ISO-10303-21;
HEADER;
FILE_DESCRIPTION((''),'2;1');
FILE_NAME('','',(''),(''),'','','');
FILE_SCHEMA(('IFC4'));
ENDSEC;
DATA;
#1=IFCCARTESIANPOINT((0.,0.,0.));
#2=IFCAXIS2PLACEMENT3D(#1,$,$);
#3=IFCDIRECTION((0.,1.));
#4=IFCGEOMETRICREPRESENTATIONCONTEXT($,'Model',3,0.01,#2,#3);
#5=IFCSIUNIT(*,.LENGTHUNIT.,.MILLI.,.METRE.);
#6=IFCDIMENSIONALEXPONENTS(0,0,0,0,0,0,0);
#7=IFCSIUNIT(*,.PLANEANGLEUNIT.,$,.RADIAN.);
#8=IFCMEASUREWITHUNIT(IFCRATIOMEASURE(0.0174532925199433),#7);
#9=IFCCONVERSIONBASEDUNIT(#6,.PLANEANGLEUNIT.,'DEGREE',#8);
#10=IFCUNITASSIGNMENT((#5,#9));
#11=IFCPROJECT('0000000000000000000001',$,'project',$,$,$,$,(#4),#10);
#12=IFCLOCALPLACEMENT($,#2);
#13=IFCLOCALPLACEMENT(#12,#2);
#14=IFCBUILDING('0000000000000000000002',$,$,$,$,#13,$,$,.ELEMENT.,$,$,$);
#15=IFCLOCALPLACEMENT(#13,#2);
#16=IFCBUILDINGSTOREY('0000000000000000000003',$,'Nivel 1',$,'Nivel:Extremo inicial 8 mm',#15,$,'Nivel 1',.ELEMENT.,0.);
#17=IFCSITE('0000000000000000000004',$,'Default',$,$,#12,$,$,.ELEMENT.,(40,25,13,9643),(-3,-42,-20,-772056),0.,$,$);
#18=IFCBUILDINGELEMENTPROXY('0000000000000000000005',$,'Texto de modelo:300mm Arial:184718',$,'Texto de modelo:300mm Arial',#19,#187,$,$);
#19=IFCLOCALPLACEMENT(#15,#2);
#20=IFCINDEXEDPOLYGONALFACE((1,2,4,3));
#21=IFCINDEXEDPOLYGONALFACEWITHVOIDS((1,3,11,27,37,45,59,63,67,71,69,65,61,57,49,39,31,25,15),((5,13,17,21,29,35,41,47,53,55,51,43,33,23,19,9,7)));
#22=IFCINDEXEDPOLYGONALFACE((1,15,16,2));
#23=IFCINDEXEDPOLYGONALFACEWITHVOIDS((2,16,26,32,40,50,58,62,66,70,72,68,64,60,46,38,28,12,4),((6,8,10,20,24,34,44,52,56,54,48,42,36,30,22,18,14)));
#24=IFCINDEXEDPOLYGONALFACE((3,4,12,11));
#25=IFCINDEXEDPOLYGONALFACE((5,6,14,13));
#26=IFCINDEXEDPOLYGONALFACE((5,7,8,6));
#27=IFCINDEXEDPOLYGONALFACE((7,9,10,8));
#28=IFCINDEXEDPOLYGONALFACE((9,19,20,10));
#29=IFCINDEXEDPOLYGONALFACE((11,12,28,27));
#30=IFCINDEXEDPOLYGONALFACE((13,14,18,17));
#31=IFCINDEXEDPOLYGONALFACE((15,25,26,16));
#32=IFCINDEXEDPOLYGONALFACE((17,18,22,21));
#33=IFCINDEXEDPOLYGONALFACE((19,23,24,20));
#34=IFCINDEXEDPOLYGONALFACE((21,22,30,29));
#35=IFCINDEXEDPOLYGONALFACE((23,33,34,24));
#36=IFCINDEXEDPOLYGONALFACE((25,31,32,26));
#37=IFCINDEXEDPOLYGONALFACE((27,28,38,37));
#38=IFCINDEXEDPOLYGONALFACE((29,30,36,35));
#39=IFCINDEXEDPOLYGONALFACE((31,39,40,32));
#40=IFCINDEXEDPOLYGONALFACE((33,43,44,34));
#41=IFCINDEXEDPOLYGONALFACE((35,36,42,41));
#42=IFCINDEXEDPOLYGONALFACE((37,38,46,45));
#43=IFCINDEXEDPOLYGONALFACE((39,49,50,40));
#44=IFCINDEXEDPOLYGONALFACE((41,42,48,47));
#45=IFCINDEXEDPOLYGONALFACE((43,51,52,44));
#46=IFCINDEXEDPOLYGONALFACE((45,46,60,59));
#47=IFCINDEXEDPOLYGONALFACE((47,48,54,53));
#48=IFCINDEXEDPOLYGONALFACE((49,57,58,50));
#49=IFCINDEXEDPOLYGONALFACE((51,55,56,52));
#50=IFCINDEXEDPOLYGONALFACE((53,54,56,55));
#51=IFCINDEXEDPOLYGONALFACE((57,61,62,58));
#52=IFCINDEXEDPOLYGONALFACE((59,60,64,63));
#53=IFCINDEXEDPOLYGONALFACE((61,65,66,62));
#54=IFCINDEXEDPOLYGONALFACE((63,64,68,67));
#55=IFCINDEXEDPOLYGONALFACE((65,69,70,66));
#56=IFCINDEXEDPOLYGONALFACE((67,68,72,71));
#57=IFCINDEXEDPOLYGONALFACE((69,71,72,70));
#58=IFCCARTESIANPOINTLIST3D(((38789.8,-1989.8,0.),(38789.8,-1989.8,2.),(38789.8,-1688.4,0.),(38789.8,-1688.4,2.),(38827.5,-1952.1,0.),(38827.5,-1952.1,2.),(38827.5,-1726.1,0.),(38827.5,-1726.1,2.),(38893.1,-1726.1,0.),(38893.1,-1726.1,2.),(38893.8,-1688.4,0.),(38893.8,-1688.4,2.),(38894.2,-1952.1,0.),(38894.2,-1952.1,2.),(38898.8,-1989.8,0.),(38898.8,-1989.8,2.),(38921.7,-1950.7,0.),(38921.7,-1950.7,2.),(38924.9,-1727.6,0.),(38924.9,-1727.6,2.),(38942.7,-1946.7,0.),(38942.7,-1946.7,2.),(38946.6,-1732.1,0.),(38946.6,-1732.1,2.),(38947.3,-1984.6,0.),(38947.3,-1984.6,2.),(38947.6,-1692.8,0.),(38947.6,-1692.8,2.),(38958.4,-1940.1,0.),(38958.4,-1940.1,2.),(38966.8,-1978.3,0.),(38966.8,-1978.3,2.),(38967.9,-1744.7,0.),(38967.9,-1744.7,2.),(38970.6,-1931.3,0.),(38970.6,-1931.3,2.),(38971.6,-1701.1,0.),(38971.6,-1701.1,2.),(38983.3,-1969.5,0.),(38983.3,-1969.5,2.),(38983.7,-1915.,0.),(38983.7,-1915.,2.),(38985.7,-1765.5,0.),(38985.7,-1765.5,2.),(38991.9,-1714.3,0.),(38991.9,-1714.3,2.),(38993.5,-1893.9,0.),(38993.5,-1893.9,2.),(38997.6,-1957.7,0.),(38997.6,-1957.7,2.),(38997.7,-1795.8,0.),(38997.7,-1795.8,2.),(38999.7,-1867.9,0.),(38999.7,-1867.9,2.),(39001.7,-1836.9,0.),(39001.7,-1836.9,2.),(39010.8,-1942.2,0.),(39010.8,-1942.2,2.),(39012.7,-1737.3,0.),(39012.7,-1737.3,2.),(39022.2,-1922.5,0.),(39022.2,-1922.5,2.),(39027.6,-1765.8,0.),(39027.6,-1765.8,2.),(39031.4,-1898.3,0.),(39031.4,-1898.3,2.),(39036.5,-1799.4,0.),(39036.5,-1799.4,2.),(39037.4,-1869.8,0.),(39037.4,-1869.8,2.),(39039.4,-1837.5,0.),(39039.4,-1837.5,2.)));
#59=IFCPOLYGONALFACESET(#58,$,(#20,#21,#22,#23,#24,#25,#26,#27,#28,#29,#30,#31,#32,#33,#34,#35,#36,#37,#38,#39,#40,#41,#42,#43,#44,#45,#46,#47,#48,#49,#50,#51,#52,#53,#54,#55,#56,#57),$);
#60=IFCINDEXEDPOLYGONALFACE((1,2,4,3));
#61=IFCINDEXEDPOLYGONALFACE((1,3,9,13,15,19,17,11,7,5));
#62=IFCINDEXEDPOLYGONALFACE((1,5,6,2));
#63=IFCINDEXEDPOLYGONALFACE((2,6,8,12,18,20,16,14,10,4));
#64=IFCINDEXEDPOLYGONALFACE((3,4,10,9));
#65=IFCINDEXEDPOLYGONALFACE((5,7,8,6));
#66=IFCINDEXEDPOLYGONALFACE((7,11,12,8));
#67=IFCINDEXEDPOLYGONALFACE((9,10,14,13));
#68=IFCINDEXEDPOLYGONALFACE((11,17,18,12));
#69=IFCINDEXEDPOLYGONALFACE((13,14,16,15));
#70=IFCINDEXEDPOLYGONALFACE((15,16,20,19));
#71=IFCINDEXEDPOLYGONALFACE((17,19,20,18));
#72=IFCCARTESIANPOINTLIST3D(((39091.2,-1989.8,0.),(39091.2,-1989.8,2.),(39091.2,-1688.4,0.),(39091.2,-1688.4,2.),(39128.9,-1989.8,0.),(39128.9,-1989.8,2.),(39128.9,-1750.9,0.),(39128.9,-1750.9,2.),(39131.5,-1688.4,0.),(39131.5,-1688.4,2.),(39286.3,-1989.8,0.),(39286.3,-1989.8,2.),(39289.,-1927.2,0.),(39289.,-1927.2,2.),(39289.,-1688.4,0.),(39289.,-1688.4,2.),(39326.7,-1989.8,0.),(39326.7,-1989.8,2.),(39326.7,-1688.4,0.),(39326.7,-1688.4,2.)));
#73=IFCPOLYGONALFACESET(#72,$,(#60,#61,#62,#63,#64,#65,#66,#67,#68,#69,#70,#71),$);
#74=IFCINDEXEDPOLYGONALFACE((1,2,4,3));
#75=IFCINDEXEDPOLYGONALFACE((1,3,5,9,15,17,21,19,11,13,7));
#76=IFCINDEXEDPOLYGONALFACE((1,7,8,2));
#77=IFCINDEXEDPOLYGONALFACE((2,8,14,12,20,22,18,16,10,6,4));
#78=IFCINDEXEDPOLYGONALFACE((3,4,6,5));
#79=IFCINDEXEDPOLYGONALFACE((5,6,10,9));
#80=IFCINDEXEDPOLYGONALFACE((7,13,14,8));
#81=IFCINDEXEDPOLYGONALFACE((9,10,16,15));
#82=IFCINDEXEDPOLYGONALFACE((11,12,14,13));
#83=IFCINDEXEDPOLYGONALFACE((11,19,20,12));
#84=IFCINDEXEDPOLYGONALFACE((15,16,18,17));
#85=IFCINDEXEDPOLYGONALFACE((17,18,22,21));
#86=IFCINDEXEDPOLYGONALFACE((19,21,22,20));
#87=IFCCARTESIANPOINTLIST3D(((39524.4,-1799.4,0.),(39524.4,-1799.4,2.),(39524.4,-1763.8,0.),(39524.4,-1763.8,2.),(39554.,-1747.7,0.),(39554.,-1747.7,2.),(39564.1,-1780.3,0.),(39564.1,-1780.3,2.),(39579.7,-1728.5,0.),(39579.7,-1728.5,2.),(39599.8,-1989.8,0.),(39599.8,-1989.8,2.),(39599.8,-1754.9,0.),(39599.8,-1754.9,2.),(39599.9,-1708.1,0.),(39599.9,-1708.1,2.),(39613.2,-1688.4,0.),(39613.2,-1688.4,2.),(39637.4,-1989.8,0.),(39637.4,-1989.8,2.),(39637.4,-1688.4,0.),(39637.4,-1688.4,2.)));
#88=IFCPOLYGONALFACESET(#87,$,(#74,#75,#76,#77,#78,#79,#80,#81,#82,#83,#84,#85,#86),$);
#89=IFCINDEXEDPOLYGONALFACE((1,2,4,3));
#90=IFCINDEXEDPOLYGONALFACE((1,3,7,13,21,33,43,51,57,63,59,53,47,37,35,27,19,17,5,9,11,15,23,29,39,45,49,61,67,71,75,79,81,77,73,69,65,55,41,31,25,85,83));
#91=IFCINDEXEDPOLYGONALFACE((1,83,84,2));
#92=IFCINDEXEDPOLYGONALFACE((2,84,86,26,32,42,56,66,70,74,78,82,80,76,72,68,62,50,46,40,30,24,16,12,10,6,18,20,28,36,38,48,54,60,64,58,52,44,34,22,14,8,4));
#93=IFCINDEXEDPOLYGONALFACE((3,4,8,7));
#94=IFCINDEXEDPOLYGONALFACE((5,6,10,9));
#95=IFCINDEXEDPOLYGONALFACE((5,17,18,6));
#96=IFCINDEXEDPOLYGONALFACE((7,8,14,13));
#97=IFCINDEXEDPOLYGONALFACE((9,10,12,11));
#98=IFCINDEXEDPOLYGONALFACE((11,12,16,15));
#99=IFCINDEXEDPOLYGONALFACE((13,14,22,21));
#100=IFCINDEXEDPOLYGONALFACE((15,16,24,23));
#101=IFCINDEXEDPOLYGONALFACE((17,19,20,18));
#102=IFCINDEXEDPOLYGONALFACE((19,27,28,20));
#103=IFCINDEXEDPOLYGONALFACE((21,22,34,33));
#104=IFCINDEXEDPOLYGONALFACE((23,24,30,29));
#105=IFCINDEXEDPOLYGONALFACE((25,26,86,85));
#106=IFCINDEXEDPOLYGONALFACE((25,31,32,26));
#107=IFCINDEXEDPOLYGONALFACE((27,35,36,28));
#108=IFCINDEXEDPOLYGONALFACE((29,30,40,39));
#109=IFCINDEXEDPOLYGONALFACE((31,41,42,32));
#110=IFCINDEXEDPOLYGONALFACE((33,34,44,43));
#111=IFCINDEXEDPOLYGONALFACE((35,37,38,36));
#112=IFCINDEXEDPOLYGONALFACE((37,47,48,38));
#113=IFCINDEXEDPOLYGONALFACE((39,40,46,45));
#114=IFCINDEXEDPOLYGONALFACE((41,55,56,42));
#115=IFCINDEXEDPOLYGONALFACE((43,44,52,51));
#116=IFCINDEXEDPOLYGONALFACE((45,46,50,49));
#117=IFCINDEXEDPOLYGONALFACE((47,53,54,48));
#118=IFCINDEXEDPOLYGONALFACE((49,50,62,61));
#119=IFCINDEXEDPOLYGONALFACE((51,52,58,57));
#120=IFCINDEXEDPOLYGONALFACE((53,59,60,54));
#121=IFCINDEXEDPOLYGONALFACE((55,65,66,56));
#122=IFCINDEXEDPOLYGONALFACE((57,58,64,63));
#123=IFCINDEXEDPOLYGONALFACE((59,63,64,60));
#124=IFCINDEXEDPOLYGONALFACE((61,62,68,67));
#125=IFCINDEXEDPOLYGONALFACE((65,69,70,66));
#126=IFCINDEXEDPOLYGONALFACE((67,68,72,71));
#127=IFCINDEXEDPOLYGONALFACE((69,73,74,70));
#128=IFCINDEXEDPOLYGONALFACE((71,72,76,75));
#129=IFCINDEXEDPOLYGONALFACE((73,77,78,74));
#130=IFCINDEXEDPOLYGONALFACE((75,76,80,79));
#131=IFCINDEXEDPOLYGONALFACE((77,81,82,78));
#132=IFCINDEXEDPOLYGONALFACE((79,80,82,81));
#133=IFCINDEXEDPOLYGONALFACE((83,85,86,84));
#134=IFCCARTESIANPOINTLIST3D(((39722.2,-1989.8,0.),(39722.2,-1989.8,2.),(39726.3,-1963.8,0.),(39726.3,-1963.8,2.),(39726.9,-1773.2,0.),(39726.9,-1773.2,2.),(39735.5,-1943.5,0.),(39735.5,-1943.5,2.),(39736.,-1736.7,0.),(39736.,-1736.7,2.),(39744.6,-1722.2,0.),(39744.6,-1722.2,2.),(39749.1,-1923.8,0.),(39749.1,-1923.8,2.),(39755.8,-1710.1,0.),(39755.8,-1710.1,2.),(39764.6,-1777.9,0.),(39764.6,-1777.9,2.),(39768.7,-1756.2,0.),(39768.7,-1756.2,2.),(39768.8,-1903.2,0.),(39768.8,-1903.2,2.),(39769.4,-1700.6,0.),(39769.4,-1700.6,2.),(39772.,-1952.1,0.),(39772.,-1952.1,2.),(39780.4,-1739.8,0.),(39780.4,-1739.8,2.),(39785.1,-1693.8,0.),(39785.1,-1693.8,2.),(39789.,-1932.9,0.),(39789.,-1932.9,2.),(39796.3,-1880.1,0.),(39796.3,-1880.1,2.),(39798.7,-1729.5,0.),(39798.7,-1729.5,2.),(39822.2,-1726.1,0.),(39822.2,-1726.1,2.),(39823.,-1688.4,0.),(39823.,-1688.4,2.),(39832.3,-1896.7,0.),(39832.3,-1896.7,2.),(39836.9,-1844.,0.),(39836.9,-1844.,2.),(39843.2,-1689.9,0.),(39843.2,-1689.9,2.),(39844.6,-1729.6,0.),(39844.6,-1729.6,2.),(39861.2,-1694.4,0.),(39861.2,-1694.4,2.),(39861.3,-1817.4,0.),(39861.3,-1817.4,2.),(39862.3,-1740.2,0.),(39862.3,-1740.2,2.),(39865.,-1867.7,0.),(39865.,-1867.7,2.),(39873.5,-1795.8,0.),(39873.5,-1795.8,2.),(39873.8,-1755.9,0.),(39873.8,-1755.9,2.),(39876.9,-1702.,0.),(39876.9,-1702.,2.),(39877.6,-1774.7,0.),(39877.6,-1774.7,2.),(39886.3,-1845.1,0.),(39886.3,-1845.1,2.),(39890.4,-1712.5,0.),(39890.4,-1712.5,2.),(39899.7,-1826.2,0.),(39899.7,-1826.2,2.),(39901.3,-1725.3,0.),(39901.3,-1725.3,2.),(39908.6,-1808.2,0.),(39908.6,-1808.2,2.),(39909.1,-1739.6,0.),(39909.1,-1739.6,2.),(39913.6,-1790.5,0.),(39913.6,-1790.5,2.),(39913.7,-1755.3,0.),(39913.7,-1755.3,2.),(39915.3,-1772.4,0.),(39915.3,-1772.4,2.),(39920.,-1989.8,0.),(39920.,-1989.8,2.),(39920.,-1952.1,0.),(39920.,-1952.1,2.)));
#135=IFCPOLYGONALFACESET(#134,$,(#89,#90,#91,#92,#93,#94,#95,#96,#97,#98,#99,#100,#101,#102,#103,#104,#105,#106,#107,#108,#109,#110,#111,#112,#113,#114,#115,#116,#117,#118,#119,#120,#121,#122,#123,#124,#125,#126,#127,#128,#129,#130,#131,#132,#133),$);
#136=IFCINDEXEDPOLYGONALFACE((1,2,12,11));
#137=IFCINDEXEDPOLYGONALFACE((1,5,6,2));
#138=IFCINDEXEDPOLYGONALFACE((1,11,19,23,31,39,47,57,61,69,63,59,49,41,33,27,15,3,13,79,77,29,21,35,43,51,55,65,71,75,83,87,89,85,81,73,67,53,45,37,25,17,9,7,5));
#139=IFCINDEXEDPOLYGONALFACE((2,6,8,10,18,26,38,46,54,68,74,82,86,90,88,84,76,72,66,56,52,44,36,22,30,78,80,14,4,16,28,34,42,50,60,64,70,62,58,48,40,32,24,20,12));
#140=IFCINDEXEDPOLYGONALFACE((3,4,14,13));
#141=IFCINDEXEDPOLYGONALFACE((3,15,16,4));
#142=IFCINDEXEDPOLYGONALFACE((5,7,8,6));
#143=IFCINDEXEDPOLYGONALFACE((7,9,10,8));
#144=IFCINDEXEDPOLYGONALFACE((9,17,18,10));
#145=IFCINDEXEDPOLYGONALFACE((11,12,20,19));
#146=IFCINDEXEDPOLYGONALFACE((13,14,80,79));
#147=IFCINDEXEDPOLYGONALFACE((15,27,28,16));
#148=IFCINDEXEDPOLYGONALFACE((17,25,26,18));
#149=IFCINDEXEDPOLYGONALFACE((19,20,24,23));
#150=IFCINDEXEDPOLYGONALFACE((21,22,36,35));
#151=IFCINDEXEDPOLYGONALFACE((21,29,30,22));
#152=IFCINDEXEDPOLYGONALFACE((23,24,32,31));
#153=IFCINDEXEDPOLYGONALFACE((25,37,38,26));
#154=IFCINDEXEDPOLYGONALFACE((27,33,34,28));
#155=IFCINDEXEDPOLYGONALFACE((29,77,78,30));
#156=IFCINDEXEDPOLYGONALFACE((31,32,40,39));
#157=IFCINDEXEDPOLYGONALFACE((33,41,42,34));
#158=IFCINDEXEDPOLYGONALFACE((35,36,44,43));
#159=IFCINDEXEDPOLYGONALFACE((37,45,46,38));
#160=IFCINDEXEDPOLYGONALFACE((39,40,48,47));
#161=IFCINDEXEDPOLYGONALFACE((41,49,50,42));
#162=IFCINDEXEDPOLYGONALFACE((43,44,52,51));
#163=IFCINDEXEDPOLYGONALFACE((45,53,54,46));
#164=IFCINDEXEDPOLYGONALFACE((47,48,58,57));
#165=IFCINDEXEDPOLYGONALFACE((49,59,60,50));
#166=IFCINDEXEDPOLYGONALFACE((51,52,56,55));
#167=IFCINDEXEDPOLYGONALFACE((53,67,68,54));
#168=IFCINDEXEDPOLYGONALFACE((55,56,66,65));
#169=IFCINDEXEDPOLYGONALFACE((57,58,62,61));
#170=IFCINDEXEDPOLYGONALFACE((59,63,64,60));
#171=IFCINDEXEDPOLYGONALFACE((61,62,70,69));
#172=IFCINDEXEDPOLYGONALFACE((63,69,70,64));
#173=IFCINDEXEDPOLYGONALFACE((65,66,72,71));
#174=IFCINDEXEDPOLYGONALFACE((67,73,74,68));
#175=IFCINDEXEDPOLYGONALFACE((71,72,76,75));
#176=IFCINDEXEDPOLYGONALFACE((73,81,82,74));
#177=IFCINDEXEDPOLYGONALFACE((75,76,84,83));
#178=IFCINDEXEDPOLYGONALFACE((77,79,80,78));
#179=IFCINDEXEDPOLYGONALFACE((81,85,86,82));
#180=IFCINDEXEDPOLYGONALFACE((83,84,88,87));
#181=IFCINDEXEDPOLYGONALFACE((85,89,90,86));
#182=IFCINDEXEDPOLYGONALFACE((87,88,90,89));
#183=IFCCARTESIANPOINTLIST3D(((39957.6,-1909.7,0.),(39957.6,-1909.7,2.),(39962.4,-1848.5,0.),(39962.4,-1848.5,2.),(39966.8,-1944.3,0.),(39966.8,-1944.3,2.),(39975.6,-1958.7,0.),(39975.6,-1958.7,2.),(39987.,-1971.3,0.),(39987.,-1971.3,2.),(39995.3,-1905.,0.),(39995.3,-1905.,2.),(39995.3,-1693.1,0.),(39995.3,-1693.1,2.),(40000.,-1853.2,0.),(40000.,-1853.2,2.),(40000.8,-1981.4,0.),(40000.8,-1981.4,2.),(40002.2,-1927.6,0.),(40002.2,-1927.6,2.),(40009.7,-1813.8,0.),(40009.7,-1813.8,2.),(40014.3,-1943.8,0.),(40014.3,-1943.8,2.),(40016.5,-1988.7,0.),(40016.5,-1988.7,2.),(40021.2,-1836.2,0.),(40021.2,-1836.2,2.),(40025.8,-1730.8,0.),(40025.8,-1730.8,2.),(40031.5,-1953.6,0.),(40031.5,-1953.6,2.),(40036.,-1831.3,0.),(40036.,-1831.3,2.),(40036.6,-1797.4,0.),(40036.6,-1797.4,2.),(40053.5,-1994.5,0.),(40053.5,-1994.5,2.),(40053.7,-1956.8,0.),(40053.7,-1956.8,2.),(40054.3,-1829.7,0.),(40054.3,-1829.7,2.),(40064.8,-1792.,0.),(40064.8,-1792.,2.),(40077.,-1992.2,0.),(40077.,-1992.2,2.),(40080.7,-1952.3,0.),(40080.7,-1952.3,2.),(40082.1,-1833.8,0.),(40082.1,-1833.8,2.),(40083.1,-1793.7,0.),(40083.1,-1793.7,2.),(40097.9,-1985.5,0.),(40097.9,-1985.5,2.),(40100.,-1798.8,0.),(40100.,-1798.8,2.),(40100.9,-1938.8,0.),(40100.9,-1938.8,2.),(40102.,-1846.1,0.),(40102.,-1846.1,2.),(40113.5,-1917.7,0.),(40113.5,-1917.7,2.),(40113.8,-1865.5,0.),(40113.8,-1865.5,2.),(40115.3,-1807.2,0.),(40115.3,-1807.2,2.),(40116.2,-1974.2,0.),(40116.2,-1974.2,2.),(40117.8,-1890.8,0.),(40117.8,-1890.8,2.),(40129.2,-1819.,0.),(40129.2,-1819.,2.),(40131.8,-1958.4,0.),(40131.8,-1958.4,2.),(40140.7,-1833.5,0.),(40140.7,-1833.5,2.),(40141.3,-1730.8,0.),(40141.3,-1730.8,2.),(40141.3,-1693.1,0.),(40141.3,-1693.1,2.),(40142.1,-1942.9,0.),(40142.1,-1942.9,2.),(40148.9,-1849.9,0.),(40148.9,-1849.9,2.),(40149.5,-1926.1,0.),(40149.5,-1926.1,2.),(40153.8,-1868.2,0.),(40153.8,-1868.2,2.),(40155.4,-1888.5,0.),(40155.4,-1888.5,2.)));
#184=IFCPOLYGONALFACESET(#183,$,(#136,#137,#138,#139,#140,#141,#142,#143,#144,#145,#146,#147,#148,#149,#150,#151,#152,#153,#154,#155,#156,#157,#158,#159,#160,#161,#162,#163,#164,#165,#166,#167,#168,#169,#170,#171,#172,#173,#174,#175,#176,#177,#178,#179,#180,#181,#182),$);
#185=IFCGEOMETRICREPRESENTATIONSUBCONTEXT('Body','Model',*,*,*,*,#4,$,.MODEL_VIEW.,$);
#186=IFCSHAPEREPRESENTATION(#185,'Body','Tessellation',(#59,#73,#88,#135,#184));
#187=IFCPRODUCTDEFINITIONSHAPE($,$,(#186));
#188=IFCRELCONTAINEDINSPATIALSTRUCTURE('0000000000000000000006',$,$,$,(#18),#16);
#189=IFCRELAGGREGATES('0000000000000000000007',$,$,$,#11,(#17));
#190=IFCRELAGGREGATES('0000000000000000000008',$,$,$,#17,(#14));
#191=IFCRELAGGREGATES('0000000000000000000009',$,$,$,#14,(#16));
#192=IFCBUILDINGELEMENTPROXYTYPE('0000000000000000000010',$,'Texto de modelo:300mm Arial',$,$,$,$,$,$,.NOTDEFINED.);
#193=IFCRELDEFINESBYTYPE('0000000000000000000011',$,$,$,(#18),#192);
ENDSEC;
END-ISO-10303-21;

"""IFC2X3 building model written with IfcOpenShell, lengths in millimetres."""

from ifc_helpers import new_model, entity, si_unit, converted_unit, direction, frame, origin, place, context, subcontext, project, spatial, polyline, outline, extrude, type_object, element, save


model = new_model("IFC2X3")

# Units and contexts
model_context = context("Model", 3, precision=0.01, world=origin(), true_north=direction((0.0, 1.0)))
body_context = subcontext(model_context, "Body", "Model", "MODEL_VIEW")
ifc_project = project(units=[si_unit("LENGTHUNIT", "METRE", prefix="MILLI"), converted_unit("PLANEANGLEUNIT", "DEGREE", entity("IfcRatioMeasure", 0.0174532925199433), si_unit("PLANEANGLEUNIT", "RADIAN"), dimensions=[0, 0, 0, 0, 0, 0, 0])], contexts=[model_context])

# Site, building, storey
site_placement = place(None, origin())
site = spatial("IfcSite", under=ifc_project, at=site_placement, Name="Default", CompositionType="ELEMENT", RefLatitude=(40, 25, 13, 9643), RefLongitude=(-3, -42, -20, -772056), RefElevation=0.0)
building_placement = place(site_placement, origin())
building = spatial("IfcBuilding", under=site, at=building_placement, CompositionType="ELEMENT")
storey_placement = place(building_placement, origin())
storey = spatial("IfcBuildingStorey", under=building, at=storey_placement, Name="Nivel 1", ObjectType="Nivel:Extremo inicial 8 mm", LongName="Nivel 1", CompositionType="ELEMENT", Elevation=0.0)

# Building element proxy
building_element_proxy_type_1 = type_object("IfcBuildingElementProxyType", Name="Texto de modelo:300mm Arial", PredefinedType="NOTDEFINED")
proxy_1_placement = place(storey_placement, frame((38789.8, -1994.5, 0.0)))
element("IfcBuildingElementProxy", 1, at=proxy_1_placement, inside=storey, type_object=building_element_proxy_type_1, Name="Texto de modelo:300mm Arial:184718", ObjectType="Texto de modelo:300mm Arial", context=body_context, shape_type="SweptSolid", body=[
    extrude(outline(polyline([(-178.4, -141.0), (-69.4, -141.0), (-21.0, -135.8), (-1.4, -129.5), (15.0, -120.7), (29.4, -108.9), (42.6, -93.4), (54.0, -73.7), (63.2, -49.5), (69.2, -21.0), (71.2, 11.3), (68.2, 49.4), (59.3, 83.0), (44.5, 111.5), (23.7, 134.5), (3.4, 147.7), (-20.6, 156.1), (-74.4, 160.4), (-178.4, 160.4), (-178.4, -141.0)]), holes=[polyline([(-140.7, -103.3), (-140.7, 122.7), (-75.1, 122.7), (-43.3, 121.2), (-21.7, 116.7), (-0.4, 104.1), (17.4, 83.3), (29.5, 53.0), (33.5, 11.9), (31.5, -19.1), (25.3, -45.1), (15.5, -66.2), (2.4, -82.5), (-9.8, -91.3), (-25.6, -97.9), (-46.5, -101.9), (-74.1, -103.3), (-140.7, -103.3)])]), frame((178.4, 145.7, 0.0)), (0.0, 0.0, 1.0), 2.0),
    extrude(outline(polyline([(-117.7, -150.7), (-80.1, -150.7), (-80.1, 88.1), (77.4, -150.7), (117.7, -150.7), (117.7, 150.7), (80.1, 150.7), (80.1, -88.1), (-77.4, 150.7), (-117.7, 150.7), (-117.7, -150.7)])), frame((419.1, 155.4, 0.0)), (0.0, 0.0, 1.0), 2.0),
    extrude(outline(polyline([(-204.4, -52.5), (97.0, -52.5), (97.0, -28.2), (77.2, -14.9), (56.9, 5.3), (37.7, 30.9), (21.6, 60.5), (-14.0, 60.5), (5.0, 20.8), (30.4, -14.9), (-204.4, -14.9), (-204.4, -52.5)])), frame((795.1, 209.1, 0.0), z_axis=(0.0, 0.0, 1.0), x_axis=(0.0, 1.0, 0.0)), (0.0, 0.0, 1.0), 2.0),
    extrude(outline(polyline([(-91.6, -150.5), (-91.6, -188.2), (106.2, -188.2), (102.1, -162.2), (92.9, -141.9), (79.3, -122.2), (59.6, -101.6), (32.1, -78.5), (-8.5, -42.4), (-32.9, -15.8), (-45.1, 5.8), (-49.2, 26.9), (-45.4, 45.8), (-33.9, 61.4), (-16.2, 72.0), (6.2, 75.5), (29.7, 72.1), (48.0, 61.8), (59.7, 45.4), (63.8, 23.7), (101.5, 28.4), (92.4, 64.9), (83.8, 79.4), (72.6, 91.5), (59.0, 101.0), (43.3, 107.8), (5.4, 113.2), (-14.8, 111.7), (-32.8, 107.2), (-48.5, 99.6), (-62.0, 89.1), (-72.9, 76.3), (-80.7, 62.0), (-85.3, 46.3), (-86.9, 29.2), (-85.2, 11.2), (-80.2, -6.5), (-71.3, -24.6), (-57.9, -43.5), (-36.6, -66.1), (-3.9, -95.1), (39.4, -131.3), (56.4, -150.5), (-91.6, -150.5)])), frame((1038.6, 192.9, 0.0), z_axis=(0.0, 0.0, -1.0), x_axis=(-1.0, 0.0, 0.0)), (0.0, 0.0, -1.0), 2.0),
    extrude(outline(polyline([(1.4, -113.1), (37.2, -113.1), (53.4, -108.4), (68.5, -100.5), (81.8, -89.8), (92.9, -76.5), (108.0, -42.2), (111.8, -18.9), (110.6, 3.0), (104.4, 23.5), (93.2, 42.7), (80.9, 56.7), (66.6, 68.1), (31.7, 83.5), (11.7, 87.1), (-7.3, 87.1), (-25.2, 83.4), (-42.2, 76.0), (-57.1, 65.7), (-69.2, 53.0), (-78.5, 38.0), (-84.8, 20.7), (-86.8, -7.9), (-77.9, -38.1), (-154.0, -1.2), (-124.3, 110.4), (-160.7, 120.1), (-198.2, -21.0), (-56.5, -92.8), (-42.3, -57.6), (-53.3, -32.8), (-54.2, -17.2), (-51.1, 0.9), (-40.0, 26.8), (-23.0, 42.8), (-1.2, 49.2), (24.3, 46.5), (49.2, 35.5), (66.3, 17.9), (74.2, -5.1), (71.6, -32.4), (62.8, -53.0), (48.9, -67.1), (30.2, -74.6), (6.6, -75.5), (1.4, -113.1)])), frame((1276.7, 115.2, 0.0), z_axis=(0.0, 0.0, 1.0), x_axis=(0.256974, -0.966418, 0.0)), (0.0, 0.0, 1.0), 2.0),
])

save(model, "model.ifc")
